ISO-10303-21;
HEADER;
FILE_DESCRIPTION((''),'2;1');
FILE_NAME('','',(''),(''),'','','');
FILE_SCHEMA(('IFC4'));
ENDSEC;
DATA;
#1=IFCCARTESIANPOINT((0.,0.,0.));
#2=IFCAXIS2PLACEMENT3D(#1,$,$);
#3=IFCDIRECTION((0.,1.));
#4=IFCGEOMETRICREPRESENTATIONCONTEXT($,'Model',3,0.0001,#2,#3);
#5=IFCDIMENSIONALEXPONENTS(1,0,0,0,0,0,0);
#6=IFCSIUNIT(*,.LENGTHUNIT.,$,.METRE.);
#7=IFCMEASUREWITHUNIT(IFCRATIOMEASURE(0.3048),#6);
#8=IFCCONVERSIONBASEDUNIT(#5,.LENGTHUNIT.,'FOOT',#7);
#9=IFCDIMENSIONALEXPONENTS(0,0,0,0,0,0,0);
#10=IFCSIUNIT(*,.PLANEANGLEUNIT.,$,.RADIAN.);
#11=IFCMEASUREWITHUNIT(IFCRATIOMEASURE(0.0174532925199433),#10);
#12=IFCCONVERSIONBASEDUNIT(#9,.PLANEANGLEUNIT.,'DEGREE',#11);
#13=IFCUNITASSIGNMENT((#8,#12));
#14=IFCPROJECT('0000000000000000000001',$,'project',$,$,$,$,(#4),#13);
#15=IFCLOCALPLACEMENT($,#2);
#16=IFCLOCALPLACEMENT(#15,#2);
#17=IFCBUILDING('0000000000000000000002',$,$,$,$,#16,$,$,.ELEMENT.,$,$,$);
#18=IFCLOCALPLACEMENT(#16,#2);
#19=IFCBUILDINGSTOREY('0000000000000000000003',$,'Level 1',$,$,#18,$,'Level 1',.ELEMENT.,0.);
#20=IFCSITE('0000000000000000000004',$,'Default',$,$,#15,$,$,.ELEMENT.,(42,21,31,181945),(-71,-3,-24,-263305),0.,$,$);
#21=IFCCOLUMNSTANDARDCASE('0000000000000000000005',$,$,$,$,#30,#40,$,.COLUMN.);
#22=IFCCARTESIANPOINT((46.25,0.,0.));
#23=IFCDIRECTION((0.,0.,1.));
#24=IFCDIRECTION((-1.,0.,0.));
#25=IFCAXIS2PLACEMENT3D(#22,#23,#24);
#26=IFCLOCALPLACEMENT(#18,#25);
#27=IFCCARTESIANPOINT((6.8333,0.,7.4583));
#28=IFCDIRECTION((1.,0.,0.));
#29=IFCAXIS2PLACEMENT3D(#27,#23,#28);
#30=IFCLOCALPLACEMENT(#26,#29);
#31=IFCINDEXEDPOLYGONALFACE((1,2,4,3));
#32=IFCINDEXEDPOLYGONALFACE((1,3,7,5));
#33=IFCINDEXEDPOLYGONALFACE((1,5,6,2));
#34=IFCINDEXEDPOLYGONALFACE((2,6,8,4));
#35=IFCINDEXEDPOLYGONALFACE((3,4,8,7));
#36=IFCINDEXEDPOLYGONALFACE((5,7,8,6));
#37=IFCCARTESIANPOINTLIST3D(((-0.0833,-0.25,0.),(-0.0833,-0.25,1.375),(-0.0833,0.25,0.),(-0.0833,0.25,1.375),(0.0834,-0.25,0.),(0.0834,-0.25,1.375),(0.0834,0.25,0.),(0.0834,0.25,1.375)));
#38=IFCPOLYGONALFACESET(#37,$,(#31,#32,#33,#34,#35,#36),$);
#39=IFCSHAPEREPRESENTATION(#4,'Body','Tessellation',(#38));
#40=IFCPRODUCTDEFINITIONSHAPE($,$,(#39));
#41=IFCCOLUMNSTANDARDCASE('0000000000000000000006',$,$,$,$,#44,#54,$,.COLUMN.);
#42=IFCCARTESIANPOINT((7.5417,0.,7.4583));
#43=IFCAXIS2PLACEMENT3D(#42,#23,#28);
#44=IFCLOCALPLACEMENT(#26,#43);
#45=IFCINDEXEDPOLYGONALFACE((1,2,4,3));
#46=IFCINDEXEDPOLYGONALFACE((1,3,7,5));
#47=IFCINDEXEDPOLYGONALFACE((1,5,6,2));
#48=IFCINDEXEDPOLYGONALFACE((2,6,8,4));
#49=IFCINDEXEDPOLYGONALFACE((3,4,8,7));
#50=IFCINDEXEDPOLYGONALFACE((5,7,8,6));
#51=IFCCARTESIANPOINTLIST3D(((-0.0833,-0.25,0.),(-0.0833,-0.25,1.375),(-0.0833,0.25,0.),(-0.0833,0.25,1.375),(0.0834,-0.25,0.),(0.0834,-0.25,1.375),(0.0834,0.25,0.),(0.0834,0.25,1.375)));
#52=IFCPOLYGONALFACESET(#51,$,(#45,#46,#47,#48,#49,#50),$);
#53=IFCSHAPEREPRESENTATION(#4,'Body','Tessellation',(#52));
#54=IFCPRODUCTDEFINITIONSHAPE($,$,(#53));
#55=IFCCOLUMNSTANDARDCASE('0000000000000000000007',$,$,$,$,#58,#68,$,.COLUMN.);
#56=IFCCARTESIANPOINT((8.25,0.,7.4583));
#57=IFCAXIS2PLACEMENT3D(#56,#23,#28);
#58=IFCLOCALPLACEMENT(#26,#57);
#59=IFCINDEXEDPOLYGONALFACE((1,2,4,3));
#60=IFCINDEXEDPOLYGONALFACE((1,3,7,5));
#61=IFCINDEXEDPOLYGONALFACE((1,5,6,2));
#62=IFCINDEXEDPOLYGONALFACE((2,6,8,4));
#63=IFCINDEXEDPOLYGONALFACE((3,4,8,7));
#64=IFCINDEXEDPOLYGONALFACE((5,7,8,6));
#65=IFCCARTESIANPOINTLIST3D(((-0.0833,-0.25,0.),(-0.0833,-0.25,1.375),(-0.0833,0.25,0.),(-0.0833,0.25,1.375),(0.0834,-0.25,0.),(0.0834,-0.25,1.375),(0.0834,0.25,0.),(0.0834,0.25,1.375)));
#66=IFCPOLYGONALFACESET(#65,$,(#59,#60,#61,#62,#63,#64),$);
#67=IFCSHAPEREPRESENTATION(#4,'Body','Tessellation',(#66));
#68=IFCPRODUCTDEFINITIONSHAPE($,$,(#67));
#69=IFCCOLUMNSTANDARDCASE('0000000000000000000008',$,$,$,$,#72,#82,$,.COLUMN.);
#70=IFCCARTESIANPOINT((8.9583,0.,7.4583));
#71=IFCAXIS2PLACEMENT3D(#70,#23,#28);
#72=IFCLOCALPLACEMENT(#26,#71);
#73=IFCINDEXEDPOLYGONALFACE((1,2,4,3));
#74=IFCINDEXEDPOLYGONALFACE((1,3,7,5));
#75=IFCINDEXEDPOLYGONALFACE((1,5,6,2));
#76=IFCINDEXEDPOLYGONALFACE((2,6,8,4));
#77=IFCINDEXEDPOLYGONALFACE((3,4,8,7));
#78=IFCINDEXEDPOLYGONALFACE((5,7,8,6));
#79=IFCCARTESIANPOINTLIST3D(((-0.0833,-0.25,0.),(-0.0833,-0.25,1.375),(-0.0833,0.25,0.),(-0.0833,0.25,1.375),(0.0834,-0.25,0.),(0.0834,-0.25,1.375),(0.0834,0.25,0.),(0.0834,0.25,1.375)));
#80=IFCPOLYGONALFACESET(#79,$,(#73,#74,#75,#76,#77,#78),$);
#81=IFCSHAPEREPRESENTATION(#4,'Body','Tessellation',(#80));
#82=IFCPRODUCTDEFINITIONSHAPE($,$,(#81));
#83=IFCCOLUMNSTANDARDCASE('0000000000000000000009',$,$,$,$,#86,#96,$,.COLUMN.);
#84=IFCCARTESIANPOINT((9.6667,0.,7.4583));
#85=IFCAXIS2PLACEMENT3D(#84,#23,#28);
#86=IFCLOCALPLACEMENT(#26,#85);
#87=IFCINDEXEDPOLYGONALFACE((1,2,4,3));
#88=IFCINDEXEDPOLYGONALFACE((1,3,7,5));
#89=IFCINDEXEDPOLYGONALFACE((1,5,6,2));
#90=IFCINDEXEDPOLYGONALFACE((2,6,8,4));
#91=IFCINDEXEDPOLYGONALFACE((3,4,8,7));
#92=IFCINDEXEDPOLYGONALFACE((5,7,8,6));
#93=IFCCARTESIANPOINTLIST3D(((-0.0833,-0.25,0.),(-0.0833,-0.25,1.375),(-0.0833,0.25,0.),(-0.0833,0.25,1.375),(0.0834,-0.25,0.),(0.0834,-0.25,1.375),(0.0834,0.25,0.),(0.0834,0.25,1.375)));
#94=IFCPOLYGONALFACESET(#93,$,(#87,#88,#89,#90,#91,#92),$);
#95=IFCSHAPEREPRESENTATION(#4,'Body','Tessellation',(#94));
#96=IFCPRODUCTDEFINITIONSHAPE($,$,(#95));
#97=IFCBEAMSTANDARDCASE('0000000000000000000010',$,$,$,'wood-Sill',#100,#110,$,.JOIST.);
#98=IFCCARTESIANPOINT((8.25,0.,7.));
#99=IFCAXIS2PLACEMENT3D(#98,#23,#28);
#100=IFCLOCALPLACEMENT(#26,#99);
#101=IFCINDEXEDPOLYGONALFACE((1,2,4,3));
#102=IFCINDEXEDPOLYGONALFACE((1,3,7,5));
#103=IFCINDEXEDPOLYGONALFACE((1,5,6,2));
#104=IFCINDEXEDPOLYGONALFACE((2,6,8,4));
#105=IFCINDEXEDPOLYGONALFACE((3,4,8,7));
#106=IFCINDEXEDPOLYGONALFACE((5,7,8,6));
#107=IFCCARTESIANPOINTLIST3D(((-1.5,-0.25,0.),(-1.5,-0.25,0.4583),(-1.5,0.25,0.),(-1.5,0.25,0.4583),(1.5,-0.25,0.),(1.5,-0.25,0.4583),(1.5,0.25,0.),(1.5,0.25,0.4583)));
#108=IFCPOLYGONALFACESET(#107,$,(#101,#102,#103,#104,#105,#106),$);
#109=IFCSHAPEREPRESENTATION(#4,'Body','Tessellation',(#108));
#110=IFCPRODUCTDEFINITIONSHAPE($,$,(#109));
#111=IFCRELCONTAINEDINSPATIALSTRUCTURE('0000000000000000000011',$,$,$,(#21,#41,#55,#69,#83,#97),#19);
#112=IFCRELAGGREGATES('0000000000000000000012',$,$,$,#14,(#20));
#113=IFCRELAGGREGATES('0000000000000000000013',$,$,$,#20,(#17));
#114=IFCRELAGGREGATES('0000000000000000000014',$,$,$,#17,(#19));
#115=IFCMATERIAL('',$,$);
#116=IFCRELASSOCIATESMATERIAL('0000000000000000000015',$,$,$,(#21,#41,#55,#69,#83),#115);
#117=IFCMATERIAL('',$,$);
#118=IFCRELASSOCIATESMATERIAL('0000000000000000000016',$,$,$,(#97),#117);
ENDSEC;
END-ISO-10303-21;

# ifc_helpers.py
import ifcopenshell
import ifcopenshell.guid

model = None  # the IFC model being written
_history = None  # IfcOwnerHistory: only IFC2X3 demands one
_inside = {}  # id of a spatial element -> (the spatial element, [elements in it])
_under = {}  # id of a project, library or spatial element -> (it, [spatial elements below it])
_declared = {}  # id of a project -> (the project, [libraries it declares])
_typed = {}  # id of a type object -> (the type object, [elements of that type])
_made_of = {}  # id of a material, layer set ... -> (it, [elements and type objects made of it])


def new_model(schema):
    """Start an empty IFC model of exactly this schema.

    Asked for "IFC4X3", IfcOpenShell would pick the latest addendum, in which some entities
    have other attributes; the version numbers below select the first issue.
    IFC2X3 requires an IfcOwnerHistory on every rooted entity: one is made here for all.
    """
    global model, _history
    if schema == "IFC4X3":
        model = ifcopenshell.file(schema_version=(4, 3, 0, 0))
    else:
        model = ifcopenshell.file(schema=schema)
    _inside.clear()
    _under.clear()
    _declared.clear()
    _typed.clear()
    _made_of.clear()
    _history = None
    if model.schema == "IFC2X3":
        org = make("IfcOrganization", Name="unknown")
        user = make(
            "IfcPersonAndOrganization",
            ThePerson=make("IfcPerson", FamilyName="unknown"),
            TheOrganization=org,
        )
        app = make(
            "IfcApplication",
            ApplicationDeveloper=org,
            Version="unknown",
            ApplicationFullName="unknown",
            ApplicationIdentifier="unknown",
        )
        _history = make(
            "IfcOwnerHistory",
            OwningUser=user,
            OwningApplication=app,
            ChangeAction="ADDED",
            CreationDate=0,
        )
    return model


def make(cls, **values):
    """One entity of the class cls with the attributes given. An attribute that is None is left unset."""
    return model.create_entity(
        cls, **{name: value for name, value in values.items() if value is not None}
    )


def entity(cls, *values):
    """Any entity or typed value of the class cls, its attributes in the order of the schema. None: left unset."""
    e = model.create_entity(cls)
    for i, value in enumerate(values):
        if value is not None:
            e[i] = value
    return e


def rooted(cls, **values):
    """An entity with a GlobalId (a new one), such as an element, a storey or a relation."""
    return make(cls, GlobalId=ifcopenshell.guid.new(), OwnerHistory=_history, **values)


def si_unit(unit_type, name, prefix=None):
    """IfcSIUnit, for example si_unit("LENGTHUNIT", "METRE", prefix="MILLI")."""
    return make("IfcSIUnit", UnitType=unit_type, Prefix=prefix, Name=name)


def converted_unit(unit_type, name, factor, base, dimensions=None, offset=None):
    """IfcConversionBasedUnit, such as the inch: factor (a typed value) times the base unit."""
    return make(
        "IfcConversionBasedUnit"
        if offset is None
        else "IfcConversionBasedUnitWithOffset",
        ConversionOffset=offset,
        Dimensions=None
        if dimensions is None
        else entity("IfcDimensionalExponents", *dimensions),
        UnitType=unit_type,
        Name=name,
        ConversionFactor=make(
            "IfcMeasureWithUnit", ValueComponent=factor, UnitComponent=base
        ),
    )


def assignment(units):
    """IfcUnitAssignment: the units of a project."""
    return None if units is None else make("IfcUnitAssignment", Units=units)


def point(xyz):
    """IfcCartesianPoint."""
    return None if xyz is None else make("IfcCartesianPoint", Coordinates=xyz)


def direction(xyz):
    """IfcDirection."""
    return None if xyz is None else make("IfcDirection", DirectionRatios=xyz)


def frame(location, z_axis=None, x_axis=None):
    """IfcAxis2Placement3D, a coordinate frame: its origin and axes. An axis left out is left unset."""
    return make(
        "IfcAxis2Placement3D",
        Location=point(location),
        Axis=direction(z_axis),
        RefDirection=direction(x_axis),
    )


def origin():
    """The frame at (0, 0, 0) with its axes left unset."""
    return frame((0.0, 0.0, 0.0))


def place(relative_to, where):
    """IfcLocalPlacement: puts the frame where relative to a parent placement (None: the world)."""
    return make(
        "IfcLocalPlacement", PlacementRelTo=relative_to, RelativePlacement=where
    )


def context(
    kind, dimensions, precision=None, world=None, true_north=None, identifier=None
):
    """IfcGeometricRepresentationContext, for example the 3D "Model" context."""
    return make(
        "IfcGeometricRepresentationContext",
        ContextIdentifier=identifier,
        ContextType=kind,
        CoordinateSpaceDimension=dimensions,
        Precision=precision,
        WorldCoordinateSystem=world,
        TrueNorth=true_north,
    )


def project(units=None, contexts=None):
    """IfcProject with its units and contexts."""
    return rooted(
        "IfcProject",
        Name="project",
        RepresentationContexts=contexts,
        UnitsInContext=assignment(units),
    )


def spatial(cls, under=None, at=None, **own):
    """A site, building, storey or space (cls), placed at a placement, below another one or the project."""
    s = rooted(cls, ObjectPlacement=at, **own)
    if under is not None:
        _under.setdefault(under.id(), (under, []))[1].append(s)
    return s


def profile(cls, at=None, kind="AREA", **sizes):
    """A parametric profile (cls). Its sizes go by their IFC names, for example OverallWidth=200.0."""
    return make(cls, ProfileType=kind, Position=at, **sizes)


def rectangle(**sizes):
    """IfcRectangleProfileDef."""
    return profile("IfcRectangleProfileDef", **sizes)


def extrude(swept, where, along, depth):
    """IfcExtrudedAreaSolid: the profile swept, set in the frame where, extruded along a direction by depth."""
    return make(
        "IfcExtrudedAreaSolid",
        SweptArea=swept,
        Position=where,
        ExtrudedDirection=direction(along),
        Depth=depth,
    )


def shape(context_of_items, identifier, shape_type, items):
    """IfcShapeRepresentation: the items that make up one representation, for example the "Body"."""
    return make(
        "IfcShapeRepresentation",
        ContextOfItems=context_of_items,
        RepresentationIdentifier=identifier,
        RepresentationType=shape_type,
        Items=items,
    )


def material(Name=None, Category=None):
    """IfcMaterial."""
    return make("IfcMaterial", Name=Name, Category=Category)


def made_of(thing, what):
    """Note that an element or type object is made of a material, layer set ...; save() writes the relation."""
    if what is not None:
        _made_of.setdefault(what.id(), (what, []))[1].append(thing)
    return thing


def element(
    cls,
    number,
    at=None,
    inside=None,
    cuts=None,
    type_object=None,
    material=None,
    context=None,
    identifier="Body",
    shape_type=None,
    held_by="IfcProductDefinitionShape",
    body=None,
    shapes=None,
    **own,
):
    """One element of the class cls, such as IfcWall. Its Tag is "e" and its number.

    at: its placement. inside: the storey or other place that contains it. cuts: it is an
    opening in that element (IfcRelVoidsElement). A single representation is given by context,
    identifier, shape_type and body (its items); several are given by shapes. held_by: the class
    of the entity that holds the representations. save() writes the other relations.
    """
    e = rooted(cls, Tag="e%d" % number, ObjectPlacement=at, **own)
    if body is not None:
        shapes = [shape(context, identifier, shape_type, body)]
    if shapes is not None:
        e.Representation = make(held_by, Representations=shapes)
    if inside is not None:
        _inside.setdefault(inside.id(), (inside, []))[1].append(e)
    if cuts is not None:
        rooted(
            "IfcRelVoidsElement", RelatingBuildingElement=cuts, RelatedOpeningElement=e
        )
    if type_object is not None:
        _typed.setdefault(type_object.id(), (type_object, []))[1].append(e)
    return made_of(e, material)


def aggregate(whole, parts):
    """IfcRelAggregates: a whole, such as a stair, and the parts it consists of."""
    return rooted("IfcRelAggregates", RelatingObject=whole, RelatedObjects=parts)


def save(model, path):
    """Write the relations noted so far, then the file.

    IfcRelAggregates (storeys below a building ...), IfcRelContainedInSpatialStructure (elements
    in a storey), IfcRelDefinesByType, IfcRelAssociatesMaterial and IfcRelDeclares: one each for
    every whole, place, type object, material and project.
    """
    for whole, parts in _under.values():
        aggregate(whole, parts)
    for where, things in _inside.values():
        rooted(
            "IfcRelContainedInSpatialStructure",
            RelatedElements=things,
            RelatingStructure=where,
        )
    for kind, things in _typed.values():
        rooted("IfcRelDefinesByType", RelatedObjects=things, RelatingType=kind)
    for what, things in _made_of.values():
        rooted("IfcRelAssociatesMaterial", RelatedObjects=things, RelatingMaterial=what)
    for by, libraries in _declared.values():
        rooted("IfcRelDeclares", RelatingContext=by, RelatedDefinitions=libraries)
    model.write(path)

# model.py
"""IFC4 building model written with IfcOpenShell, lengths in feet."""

from ifc_helpers import new_model, entity, si_unit, converted_unit, direction, frame, origin, place, context, project, spatial, rectangle, extrude, material, element, save


model = new_model("IFC4")

# Units and contexts
model_context = context("Model", 3, precision=0.0001, world=origin(), true_north=direction((0.0, 1.0)))
ifc_project = project(units=[converted_unit("LENGTHUNIT", "FOOT", entity("IfcRatioMeasure", 0.3048), si_unit("LENGTHUNIT", "METRE"), dimensions=[1, 0, 0, 0, 0, 0, 0]), converted_unit("PLANEANGLEUNIT", "DEGREE", entity("IfcRatioMeasure", 0.0174532925199433), si_unit("PLANEANGLEUNIT", "RADIAN"), dimensions=[0, 0, 0, 0, 0, 0, 0])], contexts=[model_context])

# Site, building, storey
site_placement = place(None, origin())
site = spatial("IfcSite", under=ifc_project, at=site_placement, Name="Default", CompositionType="ELEMENT", RefLatitude=(42, 21, 31, 181945), RefLongitude=(-71, -3, -24, -263305), RefElevation=0.0)
building_placement = place(site_placement, origin())
building = spatial("IfcBuilding", under=site, at=building_placement, CompositionType="ELEMENT")
storey_placement = place(building_placement, origin())
storey = spatial("IfcBuildingStorey", under=building, at=storey_placement, Name="Level 1", LongName="Level 1", CompositionType="ELEMENT", Elevation=0.0)

# Columns
placement_1 = place(storey_placement, frame((46.25, 0.0, 0.0), z_axis=(0.0, 0.0, 1.0), x_axis=(-1.0, 0.0, 0.0)))
ifc_material_1 = material(Name="")
for number, where, z_axis, x_axis in (
    (1, (6.8333, 0.0, 7.4583), (0.0, 0.0, 1.0), (1.0, 0.0, 0.0)),
    (2, (7.5417, 0.0, 7.4583), (0.0, 0.0, 1.0), (1.0, 0.0, 0.0)),
    (3, (8.25, 0.0, 7.4583), (0.0, 0.0, 1.0), (1.0, 0.0, 0.0)),
    (4, (8.9583, 0.0, 7.4583), (0.0, 0.0, 1.0), (1.0, 0.0, 0.0)),
    (5, (9.6667, 0.0, 7.4583), (0.0, 0.0, 1.0), (1.0, 0.0, 0.0)),
):
    element("IfcColumnStandardCase", number, at=place(placement_1, frame(where, z_axis=z_axis, x_axis=x_axis)), inside=storey, material=ifc_material_1, PredefinedType="COLUMN", context=model_context, shape_type="SweptSolid", body=[
        extrude(rectangle(XDim=0.1667, YDim=0.5), origin(), (0.0, 0.0, 1.0), 1.375),
    ])

# Beam
ifc_material_2 = material(Name="")
beam_placement = place(placement_1, frame((8.25, 0.0, 7.0), z_axis=(0.0, 0.0, 1.0), x_axis=(1.0, 0.0, 0.0)))
element("IfcBeamStandardCase", 6, at=beam_placement, inside=storey, material=ifc_material_2, ObjectType="wood-Sill", PredefinedType="JOIST", context=model_context, shape_type="SweptSolid", body=[
    extrude(rectangle(XDim=3.0, YDim=0.5), origin(), (0.0, 0.0, 1.0), 0.4583),
])

save(model, "model.ifc")
